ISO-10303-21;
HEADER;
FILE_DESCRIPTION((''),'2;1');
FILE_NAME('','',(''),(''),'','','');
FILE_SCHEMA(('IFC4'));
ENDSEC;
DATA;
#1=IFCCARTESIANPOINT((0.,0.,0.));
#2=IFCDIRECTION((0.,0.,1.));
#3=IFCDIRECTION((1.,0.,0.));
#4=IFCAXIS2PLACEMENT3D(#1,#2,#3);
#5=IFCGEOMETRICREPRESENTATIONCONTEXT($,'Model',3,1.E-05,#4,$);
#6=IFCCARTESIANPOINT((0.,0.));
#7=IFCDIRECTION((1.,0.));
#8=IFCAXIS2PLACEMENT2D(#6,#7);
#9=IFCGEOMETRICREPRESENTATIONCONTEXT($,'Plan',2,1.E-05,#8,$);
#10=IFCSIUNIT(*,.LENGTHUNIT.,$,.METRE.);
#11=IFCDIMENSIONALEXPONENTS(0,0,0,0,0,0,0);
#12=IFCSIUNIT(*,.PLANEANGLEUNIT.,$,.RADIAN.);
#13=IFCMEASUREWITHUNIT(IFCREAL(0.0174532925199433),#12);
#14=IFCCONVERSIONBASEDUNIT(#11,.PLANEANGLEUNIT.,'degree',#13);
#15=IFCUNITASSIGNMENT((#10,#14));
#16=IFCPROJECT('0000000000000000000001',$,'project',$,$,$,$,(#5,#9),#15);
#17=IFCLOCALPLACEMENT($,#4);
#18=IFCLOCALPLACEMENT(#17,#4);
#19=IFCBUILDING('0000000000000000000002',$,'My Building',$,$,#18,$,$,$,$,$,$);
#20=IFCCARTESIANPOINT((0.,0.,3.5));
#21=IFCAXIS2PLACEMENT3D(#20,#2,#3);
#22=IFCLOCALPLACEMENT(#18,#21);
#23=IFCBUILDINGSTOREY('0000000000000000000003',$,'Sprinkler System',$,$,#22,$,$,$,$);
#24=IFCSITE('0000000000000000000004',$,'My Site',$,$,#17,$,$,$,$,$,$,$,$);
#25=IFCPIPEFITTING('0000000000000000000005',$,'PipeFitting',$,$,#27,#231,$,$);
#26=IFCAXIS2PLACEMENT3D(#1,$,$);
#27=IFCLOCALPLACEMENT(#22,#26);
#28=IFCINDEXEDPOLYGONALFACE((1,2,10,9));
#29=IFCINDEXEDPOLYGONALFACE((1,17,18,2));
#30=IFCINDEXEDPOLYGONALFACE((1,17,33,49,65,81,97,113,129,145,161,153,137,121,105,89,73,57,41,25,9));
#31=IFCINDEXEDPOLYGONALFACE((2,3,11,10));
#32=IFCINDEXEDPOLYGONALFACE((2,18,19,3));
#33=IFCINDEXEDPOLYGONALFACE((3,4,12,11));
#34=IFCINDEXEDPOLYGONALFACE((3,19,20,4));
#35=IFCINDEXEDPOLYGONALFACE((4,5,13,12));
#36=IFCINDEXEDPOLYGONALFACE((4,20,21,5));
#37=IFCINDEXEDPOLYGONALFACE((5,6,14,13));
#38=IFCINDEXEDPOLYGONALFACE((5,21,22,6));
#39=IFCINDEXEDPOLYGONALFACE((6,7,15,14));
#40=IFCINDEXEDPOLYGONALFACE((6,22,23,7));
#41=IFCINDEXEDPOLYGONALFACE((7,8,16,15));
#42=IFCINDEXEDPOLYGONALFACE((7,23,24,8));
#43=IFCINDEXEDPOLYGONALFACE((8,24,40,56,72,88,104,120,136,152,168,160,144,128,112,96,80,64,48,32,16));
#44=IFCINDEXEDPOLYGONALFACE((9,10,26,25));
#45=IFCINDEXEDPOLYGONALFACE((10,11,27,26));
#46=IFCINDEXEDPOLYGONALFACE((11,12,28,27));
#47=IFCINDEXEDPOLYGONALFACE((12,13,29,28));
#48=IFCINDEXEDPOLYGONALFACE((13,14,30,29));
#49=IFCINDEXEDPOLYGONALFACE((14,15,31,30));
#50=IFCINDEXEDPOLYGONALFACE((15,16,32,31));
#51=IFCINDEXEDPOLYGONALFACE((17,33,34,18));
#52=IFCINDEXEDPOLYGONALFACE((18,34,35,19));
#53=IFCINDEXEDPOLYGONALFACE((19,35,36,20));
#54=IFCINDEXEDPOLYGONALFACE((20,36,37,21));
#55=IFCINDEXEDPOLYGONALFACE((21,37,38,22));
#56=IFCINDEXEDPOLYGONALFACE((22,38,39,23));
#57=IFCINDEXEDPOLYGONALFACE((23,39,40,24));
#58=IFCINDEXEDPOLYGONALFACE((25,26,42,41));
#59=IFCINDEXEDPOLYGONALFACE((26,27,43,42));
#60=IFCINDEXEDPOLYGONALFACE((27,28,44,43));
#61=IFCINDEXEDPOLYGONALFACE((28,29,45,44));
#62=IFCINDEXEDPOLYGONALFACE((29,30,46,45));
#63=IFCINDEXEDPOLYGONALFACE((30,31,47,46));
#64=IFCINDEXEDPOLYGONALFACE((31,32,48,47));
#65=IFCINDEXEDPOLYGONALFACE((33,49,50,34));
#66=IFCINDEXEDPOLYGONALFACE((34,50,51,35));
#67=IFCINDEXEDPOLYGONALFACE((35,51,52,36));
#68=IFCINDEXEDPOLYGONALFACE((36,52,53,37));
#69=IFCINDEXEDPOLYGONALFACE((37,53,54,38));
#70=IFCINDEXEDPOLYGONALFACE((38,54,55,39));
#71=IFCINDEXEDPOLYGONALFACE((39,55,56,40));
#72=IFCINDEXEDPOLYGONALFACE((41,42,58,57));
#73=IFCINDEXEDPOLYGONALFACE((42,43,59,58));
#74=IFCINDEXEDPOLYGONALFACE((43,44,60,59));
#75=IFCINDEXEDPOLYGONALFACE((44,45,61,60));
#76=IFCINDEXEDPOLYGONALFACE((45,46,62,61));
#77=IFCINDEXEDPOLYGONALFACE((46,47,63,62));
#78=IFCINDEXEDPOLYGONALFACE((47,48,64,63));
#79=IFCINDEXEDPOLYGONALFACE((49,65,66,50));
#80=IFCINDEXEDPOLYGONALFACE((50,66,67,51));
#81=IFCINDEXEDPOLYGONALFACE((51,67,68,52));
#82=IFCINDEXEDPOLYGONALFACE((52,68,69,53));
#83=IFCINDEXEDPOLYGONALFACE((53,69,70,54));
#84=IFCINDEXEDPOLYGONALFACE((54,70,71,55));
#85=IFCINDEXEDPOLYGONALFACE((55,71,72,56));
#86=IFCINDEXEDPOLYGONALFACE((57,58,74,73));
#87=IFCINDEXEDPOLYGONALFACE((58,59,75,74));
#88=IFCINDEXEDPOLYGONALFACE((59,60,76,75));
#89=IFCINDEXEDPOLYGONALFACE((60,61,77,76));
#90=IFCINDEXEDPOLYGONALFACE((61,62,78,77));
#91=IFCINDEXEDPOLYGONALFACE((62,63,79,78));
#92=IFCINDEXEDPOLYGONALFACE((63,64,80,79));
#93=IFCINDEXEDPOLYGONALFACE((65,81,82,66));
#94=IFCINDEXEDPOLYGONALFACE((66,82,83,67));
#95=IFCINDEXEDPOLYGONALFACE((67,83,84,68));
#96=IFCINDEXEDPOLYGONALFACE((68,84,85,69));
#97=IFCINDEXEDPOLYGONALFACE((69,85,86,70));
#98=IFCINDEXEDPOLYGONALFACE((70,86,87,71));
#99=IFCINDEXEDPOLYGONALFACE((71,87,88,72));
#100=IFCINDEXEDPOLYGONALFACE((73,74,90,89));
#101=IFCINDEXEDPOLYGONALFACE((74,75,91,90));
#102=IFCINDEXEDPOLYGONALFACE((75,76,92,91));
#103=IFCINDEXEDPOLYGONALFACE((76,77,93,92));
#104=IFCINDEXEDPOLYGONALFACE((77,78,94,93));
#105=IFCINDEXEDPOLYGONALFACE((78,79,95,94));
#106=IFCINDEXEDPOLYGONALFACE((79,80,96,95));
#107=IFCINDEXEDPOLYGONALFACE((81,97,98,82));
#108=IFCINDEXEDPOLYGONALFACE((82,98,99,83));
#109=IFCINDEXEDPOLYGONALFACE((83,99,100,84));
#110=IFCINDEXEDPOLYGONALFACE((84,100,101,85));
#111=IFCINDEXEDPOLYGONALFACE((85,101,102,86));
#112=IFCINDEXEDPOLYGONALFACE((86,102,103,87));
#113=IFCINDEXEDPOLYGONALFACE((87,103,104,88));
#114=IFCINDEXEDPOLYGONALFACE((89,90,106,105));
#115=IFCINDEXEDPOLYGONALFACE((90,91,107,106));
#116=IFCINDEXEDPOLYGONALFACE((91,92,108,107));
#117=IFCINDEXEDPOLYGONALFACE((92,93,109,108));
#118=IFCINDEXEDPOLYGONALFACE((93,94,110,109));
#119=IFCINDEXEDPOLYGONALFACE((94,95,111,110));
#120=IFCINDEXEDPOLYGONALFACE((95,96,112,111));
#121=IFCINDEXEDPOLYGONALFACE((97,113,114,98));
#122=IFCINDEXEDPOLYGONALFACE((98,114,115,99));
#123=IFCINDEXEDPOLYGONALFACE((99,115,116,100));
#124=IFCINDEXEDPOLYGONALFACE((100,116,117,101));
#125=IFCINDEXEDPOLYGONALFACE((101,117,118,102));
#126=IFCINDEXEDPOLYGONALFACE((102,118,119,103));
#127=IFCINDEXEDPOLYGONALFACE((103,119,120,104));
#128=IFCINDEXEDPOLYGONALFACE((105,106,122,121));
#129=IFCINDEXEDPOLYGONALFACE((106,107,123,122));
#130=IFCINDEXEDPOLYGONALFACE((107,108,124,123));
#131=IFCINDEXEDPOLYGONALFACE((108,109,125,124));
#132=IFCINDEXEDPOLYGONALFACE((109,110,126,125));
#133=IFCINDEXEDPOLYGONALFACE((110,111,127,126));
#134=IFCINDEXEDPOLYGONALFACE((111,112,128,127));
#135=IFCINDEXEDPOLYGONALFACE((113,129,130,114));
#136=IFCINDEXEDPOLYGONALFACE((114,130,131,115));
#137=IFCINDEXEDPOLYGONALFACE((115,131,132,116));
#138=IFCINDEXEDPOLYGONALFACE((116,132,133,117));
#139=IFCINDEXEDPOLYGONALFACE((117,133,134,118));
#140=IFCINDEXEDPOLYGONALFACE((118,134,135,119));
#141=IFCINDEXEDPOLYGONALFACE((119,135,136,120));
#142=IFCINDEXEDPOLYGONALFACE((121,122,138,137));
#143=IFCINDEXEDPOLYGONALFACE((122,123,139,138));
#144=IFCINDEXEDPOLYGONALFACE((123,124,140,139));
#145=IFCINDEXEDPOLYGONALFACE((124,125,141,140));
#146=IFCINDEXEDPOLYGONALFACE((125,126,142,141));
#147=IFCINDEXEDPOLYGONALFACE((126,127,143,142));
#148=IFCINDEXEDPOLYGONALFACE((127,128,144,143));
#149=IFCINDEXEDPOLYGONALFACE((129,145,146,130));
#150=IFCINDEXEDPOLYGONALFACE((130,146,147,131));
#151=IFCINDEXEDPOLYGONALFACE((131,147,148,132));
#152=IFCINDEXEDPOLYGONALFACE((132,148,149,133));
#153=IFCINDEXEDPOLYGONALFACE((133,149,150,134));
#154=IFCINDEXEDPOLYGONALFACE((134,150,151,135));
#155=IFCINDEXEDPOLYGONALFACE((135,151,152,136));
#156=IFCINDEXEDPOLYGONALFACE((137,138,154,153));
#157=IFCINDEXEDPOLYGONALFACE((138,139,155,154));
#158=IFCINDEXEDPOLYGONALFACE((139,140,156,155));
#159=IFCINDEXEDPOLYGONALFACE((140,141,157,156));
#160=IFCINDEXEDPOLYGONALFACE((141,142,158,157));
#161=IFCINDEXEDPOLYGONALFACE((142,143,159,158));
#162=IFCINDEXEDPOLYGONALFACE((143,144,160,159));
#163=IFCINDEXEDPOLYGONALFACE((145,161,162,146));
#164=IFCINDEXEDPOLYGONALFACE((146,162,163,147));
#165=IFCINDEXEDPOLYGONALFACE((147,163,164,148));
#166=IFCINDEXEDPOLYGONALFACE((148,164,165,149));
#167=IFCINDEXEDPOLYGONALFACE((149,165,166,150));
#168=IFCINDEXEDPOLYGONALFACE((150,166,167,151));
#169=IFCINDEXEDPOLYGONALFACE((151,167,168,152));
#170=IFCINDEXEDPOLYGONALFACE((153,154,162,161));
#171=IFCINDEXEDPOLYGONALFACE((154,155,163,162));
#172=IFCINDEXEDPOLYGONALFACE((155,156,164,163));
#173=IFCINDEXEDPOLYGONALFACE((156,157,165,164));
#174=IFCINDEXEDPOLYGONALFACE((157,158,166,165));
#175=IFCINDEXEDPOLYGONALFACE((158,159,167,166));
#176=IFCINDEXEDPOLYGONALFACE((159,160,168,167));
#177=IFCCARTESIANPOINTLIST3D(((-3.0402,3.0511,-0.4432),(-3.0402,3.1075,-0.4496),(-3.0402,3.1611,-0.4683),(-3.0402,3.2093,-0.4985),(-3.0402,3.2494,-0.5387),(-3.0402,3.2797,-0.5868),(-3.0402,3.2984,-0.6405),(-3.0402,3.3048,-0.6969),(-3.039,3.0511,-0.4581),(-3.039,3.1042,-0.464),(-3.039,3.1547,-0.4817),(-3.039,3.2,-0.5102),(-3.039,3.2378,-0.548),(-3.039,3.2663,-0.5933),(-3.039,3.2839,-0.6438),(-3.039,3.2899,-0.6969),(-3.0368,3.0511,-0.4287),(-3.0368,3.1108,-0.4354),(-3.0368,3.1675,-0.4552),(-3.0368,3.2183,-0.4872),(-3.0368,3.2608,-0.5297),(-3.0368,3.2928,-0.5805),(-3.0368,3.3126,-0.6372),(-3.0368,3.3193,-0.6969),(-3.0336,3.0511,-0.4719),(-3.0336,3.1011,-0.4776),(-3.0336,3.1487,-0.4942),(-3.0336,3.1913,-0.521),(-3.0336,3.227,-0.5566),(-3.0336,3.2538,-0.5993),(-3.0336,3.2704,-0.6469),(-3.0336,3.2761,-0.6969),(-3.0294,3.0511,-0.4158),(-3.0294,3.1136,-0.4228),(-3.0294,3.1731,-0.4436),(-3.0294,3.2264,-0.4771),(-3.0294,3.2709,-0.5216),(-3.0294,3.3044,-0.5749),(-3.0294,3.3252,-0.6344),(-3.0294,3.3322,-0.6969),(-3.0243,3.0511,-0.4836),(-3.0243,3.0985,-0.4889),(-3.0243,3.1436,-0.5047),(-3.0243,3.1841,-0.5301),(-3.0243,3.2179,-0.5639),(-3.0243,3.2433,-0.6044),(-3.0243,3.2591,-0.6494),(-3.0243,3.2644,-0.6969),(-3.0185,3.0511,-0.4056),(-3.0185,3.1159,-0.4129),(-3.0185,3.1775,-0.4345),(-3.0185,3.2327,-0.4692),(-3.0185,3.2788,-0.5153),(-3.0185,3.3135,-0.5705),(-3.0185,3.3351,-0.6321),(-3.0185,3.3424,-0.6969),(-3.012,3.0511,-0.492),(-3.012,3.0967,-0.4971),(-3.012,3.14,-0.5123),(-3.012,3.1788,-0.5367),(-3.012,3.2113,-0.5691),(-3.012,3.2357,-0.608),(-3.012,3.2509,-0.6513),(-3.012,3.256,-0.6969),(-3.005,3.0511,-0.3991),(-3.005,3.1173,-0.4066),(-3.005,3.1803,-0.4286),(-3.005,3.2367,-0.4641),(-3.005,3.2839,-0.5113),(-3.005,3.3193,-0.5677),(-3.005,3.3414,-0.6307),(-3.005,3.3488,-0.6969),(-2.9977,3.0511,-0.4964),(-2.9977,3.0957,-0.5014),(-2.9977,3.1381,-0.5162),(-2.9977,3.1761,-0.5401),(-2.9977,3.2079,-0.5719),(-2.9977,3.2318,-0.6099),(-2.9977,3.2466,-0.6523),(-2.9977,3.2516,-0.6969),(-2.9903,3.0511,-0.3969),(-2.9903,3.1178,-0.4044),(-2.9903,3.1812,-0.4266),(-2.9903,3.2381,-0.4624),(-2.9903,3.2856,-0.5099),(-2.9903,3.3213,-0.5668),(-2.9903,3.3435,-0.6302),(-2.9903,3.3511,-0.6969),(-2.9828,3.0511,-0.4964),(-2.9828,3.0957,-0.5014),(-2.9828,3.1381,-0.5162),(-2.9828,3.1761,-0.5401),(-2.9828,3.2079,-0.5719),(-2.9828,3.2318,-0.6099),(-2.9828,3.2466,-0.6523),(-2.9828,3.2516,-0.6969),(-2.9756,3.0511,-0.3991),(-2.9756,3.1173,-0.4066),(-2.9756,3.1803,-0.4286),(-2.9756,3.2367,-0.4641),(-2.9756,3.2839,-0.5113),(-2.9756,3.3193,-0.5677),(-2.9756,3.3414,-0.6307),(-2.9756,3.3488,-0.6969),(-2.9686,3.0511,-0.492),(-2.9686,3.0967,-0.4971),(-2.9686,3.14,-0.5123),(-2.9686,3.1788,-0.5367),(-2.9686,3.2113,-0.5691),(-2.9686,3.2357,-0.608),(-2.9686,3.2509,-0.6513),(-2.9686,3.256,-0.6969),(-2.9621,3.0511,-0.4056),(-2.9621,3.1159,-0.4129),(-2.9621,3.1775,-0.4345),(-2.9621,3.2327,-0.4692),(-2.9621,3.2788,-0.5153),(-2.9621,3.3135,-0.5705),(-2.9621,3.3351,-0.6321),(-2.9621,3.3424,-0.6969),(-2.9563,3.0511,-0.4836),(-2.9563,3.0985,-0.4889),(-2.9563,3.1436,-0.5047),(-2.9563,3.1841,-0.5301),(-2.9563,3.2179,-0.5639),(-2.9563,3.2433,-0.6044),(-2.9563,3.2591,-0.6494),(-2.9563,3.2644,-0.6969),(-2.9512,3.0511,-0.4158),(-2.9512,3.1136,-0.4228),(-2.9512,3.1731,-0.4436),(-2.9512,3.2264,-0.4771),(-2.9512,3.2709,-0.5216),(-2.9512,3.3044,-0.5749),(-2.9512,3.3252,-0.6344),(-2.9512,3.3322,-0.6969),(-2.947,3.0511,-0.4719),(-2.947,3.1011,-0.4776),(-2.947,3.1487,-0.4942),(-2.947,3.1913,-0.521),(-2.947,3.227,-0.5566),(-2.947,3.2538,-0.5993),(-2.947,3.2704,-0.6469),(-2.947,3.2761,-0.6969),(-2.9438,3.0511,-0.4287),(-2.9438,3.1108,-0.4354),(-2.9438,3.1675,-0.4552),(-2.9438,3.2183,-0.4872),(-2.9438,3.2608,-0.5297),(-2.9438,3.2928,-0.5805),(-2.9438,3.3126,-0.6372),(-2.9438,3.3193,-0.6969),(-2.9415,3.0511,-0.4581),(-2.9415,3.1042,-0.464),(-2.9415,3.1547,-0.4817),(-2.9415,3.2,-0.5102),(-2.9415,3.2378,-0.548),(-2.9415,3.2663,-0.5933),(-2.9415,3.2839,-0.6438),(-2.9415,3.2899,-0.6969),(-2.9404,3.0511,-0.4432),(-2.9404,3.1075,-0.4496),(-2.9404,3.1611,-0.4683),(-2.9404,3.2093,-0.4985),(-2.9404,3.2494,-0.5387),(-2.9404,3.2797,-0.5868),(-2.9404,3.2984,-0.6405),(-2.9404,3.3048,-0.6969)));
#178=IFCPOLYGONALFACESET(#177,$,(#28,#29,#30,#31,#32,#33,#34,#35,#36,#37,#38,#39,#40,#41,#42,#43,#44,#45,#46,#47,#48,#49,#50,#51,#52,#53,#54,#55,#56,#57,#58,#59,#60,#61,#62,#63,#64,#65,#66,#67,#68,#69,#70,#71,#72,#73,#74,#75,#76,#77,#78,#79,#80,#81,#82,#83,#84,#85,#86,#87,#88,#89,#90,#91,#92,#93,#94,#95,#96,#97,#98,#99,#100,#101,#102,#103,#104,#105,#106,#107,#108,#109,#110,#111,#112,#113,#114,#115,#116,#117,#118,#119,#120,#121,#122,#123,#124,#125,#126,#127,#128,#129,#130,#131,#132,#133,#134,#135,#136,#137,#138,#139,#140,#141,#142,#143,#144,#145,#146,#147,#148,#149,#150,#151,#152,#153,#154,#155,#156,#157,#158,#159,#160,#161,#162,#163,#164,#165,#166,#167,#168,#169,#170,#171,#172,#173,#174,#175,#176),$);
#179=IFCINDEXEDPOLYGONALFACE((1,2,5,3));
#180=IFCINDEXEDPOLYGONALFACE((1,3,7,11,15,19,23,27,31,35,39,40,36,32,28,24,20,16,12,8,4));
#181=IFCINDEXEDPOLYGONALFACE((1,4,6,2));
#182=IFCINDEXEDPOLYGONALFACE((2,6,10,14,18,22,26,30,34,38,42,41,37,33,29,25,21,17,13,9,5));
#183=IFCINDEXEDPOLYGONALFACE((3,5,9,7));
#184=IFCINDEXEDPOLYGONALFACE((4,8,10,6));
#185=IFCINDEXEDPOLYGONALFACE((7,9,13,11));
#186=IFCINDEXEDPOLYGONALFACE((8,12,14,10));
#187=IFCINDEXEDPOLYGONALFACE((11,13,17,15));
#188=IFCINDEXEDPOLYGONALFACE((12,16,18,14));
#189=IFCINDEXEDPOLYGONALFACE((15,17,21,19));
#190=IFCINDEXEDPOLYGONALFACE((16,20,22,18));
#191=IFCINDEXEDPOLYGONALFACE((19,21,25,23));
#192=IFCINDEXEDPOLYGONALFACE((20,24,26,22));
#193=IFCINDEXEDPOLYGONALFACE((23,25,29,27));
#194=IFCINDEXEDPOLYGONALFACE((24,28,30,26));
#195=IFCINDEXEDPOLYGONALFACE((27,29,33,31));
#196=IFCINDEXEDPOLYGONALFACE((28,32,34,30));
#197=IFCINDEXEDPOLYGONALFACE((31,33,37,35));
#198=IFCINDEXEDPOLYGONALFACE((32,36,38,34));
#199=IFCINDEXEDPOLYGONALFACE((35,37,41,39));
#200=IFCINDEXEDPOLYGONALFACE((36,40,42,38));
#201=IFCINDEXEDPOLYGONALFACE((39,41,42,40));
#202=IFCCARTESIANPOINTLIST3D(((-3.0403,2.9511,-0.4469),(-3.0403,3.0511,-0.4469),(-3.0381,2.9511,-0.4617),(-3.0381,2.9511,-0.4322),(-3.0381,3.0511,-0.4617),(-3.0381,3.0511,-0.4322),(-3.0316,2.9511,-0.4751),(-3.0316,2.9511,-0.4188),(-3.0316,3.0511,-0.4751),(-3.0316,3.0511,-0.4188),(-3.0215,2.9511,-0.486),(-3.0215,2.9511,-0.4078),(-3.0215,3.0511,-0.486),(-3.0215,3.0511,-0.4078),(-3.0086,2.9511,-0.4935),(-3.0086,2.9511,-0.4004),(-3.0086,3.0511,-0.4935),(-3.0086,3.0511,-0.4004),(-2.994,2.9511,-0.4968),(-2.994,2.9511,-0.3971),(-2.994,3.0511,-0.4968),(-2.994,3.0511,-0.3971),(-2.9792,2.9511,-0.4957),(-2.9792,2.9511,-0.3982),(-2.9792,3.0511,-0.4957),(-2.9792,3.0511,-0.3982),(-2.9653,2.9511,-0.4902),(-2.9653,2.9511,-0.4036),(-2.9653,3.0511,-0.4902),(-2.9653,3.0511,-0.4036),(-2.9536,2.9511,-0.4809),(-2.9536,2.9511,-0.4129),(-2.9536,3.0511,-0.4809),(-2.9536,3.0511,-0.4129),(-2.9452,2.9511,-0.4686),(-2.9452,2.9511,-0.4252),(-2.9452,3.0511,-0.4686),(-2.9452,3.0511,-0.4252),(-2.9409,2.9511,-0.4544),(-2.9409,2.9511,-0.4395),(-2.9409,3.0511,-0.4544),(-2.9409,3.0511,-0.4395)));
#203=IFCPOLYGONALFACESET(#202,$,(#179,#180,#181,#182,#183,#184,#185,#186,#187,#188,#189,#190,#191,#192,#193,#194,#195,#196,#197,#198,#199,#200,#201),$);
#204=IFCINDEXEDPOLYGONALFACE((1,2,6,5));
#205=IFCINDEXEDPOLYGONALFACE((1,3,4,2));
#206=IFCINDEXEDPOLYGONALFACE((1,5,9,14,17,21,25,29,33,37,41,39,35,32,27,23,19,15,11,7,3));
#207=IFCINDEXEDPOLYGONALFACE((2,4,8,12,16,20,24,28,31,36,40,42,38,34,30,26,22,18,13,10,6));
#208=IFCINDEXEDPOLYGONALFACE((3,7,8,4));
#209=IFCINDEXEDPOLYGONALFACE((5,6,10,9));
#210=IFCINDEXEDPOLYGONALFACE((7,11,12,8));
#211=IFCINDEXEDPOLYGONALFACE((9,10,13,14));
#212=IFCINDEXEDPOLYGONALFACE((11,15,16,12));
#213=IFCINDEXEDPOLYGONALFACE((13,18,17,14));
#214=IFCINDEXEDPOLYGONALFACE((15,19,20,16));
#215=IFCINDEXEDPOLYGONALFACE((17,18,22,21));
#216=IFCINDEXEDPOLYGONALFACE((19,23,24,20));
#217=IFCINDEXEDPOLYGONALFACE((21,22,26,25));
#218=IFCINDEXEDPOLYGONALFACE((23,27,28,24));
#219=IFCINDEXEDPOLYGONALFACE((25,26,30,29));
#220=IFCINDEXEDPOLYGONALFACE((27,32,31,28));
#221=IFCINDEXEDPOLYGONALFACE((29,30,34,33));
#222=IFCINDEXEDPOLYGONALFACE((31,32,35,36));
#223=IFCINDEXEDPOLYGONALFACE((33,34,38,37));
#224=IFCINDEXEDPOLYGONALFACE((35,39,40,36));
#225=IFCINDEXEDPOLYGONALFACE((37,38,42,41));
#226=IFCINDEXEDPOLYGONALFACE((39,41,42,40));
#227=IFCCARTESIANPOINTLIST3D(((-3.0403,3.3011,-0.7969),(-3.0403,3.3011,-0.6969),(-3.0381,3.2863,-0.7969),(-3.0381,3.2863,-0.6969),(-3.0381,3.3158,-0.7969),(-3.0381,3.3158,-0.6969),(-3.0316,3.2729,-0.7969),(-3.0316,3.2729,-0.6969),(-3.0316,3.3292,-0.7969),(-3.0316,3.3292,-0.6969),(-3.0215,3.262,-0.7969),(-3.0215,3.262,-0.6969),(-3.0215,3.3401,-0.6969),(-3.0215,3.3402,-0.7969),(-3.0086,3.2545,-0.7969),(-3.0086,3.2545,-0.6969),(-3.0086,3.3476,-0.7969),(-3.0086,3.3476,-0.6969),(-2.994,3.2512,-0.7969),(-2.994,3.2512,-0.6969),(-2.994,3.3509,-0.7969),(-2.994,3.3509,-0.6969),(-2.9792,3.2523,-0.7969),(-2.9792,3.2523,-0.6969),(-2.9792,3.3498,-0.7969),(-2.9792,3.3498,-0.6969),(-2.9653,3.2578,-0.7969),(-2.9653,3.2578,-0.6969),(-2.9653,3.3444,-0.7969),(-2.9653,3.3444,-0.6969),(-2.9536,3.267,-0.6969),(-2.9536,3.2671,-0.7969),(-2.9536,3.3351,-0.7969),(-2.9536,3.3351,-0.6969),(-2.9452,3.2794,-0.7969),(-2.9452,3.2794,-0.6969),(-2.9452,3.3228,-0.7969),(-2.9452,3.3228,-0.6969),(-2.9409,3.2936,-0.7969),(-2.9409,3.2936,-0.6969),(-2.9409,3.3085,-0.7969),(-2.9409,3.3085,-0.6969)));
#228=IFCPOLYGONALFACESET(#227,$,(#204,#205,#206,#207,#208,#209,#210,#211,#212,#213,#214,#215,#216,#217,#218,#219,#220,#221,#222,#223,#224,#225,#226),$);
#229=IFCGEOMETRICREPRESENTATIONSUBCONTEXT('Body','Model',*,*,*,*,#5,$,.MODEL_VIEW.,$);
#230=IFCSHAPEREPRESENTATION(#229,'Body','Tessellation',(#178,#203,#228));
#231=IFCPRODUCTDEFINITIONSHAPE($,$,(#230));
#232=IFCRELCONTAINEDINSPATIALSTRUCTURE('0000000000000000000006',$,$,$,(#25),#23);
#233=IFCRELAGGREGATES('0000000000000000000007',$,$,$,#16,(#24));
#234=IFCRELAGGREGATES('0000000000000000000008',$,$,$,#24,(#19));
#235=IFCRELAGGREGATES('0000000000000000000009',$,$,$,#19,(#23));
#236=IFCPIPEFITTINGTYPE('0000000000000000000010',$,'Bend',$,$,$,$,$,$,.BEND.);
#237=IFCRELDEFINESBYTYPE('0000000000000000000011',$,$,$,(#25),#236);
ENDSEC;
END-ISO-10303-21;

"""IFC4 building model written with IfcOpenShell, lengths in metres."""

from ifc_helpers import new_model, entity, si_unit, converted_unit, frame, origin_with_axes, origin_2d_with_axis, place, context, subcontext, project, spatial, circle, extrude, source, transform, mapped, type_object, type_shapes, element, save


model = new_model("IFC4")

# Units and contexts
model_context = context("Model", 3, precision=1e-05, world=origin_with_axes())
plan_context = context("Plan", 2, precision=1e-05, world=origin_2d_with_axis())
body_context = subcontext(model_context, "Body", "Model", "MODEL_VIEW")
ifc_project = project(units=[si_unit("LENGTHUNIT", "METRE"), converted_unit("PLANEANGLEUNIT", "degree", entity("IfcReal", 0.0174532925199433), si_unit("PLANEANGLEUNIT", "RADIAN"), dimensions=[0, 0, 0, 0, 0, 0, 0])], contexts=[model_context, plan_context])

# Site, building, storey
site_placement = place(None, origin_with_axes())
site = spatial("IfcSite", under=ifc_project, at=site_placement, Name="My Site")
building_placement = place(site_placement, origin_with_axes())
building = spatial("IfcBuilding", under=site, at=building_placement, Name="My Building")
storey_placement = place(building_placement, frame((0.0, 0.0, 3.5), z_axis=(0.0, 0.0, 1.0), x_axis=(1.0, 0.0, 0.0)))
storey = spatial("IfcBuildingStorey", under=building, at=storey_placement, Name="Sprinkler System")

# Pipe fitting
pipe_fitting_type_1 = type_object("IfcPipeFittingType", Name="Bend", PredefinedType="BEND")
shared_shape_1 = source(origin_with_axes(), body_context, "Body", "SolidModel", [
    entity("IfcSweptDiskSolid", entity("IfcIndexedPolyCurve", entity("IfcCartesianPointList3D", [[0.0, 0.0, 0.1], [0.0, -0.0732, 0.2768], [0.0, -0.25, 0.35]]), [entity("IfcArcIndex", [1, 2, 3])]), 0.05),
    extrude(circle(Radius=0.05), origin_with_axes(), (0.0, 0.0, 1.0), 0.1),
    extrude(circle(Radius=0.05), frame((0.0, -0.25, 0.35), z_axis=(0.0, -1.0, 0.000044), x_axis=(1.0, 0.0, 0.0)), (0.0, 0.0, 1.0), 0.1),
])
type_shapes(pipe_fitting_type_1, [shared_shape_1])
for number, where, z_axis, x_axis, name in (
    (1, (-2.9903, 2.9511, -0.4469), (0.0, 1.0, -0.00001), (-1.0, 0.0, 0.0), "PipeFitting"),
):
    element("IfcPipeFitting", number, at=place(storey_placement, frame(where, z_axis=z_axis, x_axis=x_axis)), inside=storey, type_object=pipe_fitting_type_1, Name=name, context=body_context, shape_type="MappedRepresentation", body=[
        mapped(shared_shape_1, transform((0.0, 0.0, 0.0), x_axis=(1.0, 0.0, 0.0), y_axis=(0.0, 1.0, 0.0), z_axis=(0.0, 0.0, 1.0), scale=1.0)),
    ])

save(model, "model.ifc")
